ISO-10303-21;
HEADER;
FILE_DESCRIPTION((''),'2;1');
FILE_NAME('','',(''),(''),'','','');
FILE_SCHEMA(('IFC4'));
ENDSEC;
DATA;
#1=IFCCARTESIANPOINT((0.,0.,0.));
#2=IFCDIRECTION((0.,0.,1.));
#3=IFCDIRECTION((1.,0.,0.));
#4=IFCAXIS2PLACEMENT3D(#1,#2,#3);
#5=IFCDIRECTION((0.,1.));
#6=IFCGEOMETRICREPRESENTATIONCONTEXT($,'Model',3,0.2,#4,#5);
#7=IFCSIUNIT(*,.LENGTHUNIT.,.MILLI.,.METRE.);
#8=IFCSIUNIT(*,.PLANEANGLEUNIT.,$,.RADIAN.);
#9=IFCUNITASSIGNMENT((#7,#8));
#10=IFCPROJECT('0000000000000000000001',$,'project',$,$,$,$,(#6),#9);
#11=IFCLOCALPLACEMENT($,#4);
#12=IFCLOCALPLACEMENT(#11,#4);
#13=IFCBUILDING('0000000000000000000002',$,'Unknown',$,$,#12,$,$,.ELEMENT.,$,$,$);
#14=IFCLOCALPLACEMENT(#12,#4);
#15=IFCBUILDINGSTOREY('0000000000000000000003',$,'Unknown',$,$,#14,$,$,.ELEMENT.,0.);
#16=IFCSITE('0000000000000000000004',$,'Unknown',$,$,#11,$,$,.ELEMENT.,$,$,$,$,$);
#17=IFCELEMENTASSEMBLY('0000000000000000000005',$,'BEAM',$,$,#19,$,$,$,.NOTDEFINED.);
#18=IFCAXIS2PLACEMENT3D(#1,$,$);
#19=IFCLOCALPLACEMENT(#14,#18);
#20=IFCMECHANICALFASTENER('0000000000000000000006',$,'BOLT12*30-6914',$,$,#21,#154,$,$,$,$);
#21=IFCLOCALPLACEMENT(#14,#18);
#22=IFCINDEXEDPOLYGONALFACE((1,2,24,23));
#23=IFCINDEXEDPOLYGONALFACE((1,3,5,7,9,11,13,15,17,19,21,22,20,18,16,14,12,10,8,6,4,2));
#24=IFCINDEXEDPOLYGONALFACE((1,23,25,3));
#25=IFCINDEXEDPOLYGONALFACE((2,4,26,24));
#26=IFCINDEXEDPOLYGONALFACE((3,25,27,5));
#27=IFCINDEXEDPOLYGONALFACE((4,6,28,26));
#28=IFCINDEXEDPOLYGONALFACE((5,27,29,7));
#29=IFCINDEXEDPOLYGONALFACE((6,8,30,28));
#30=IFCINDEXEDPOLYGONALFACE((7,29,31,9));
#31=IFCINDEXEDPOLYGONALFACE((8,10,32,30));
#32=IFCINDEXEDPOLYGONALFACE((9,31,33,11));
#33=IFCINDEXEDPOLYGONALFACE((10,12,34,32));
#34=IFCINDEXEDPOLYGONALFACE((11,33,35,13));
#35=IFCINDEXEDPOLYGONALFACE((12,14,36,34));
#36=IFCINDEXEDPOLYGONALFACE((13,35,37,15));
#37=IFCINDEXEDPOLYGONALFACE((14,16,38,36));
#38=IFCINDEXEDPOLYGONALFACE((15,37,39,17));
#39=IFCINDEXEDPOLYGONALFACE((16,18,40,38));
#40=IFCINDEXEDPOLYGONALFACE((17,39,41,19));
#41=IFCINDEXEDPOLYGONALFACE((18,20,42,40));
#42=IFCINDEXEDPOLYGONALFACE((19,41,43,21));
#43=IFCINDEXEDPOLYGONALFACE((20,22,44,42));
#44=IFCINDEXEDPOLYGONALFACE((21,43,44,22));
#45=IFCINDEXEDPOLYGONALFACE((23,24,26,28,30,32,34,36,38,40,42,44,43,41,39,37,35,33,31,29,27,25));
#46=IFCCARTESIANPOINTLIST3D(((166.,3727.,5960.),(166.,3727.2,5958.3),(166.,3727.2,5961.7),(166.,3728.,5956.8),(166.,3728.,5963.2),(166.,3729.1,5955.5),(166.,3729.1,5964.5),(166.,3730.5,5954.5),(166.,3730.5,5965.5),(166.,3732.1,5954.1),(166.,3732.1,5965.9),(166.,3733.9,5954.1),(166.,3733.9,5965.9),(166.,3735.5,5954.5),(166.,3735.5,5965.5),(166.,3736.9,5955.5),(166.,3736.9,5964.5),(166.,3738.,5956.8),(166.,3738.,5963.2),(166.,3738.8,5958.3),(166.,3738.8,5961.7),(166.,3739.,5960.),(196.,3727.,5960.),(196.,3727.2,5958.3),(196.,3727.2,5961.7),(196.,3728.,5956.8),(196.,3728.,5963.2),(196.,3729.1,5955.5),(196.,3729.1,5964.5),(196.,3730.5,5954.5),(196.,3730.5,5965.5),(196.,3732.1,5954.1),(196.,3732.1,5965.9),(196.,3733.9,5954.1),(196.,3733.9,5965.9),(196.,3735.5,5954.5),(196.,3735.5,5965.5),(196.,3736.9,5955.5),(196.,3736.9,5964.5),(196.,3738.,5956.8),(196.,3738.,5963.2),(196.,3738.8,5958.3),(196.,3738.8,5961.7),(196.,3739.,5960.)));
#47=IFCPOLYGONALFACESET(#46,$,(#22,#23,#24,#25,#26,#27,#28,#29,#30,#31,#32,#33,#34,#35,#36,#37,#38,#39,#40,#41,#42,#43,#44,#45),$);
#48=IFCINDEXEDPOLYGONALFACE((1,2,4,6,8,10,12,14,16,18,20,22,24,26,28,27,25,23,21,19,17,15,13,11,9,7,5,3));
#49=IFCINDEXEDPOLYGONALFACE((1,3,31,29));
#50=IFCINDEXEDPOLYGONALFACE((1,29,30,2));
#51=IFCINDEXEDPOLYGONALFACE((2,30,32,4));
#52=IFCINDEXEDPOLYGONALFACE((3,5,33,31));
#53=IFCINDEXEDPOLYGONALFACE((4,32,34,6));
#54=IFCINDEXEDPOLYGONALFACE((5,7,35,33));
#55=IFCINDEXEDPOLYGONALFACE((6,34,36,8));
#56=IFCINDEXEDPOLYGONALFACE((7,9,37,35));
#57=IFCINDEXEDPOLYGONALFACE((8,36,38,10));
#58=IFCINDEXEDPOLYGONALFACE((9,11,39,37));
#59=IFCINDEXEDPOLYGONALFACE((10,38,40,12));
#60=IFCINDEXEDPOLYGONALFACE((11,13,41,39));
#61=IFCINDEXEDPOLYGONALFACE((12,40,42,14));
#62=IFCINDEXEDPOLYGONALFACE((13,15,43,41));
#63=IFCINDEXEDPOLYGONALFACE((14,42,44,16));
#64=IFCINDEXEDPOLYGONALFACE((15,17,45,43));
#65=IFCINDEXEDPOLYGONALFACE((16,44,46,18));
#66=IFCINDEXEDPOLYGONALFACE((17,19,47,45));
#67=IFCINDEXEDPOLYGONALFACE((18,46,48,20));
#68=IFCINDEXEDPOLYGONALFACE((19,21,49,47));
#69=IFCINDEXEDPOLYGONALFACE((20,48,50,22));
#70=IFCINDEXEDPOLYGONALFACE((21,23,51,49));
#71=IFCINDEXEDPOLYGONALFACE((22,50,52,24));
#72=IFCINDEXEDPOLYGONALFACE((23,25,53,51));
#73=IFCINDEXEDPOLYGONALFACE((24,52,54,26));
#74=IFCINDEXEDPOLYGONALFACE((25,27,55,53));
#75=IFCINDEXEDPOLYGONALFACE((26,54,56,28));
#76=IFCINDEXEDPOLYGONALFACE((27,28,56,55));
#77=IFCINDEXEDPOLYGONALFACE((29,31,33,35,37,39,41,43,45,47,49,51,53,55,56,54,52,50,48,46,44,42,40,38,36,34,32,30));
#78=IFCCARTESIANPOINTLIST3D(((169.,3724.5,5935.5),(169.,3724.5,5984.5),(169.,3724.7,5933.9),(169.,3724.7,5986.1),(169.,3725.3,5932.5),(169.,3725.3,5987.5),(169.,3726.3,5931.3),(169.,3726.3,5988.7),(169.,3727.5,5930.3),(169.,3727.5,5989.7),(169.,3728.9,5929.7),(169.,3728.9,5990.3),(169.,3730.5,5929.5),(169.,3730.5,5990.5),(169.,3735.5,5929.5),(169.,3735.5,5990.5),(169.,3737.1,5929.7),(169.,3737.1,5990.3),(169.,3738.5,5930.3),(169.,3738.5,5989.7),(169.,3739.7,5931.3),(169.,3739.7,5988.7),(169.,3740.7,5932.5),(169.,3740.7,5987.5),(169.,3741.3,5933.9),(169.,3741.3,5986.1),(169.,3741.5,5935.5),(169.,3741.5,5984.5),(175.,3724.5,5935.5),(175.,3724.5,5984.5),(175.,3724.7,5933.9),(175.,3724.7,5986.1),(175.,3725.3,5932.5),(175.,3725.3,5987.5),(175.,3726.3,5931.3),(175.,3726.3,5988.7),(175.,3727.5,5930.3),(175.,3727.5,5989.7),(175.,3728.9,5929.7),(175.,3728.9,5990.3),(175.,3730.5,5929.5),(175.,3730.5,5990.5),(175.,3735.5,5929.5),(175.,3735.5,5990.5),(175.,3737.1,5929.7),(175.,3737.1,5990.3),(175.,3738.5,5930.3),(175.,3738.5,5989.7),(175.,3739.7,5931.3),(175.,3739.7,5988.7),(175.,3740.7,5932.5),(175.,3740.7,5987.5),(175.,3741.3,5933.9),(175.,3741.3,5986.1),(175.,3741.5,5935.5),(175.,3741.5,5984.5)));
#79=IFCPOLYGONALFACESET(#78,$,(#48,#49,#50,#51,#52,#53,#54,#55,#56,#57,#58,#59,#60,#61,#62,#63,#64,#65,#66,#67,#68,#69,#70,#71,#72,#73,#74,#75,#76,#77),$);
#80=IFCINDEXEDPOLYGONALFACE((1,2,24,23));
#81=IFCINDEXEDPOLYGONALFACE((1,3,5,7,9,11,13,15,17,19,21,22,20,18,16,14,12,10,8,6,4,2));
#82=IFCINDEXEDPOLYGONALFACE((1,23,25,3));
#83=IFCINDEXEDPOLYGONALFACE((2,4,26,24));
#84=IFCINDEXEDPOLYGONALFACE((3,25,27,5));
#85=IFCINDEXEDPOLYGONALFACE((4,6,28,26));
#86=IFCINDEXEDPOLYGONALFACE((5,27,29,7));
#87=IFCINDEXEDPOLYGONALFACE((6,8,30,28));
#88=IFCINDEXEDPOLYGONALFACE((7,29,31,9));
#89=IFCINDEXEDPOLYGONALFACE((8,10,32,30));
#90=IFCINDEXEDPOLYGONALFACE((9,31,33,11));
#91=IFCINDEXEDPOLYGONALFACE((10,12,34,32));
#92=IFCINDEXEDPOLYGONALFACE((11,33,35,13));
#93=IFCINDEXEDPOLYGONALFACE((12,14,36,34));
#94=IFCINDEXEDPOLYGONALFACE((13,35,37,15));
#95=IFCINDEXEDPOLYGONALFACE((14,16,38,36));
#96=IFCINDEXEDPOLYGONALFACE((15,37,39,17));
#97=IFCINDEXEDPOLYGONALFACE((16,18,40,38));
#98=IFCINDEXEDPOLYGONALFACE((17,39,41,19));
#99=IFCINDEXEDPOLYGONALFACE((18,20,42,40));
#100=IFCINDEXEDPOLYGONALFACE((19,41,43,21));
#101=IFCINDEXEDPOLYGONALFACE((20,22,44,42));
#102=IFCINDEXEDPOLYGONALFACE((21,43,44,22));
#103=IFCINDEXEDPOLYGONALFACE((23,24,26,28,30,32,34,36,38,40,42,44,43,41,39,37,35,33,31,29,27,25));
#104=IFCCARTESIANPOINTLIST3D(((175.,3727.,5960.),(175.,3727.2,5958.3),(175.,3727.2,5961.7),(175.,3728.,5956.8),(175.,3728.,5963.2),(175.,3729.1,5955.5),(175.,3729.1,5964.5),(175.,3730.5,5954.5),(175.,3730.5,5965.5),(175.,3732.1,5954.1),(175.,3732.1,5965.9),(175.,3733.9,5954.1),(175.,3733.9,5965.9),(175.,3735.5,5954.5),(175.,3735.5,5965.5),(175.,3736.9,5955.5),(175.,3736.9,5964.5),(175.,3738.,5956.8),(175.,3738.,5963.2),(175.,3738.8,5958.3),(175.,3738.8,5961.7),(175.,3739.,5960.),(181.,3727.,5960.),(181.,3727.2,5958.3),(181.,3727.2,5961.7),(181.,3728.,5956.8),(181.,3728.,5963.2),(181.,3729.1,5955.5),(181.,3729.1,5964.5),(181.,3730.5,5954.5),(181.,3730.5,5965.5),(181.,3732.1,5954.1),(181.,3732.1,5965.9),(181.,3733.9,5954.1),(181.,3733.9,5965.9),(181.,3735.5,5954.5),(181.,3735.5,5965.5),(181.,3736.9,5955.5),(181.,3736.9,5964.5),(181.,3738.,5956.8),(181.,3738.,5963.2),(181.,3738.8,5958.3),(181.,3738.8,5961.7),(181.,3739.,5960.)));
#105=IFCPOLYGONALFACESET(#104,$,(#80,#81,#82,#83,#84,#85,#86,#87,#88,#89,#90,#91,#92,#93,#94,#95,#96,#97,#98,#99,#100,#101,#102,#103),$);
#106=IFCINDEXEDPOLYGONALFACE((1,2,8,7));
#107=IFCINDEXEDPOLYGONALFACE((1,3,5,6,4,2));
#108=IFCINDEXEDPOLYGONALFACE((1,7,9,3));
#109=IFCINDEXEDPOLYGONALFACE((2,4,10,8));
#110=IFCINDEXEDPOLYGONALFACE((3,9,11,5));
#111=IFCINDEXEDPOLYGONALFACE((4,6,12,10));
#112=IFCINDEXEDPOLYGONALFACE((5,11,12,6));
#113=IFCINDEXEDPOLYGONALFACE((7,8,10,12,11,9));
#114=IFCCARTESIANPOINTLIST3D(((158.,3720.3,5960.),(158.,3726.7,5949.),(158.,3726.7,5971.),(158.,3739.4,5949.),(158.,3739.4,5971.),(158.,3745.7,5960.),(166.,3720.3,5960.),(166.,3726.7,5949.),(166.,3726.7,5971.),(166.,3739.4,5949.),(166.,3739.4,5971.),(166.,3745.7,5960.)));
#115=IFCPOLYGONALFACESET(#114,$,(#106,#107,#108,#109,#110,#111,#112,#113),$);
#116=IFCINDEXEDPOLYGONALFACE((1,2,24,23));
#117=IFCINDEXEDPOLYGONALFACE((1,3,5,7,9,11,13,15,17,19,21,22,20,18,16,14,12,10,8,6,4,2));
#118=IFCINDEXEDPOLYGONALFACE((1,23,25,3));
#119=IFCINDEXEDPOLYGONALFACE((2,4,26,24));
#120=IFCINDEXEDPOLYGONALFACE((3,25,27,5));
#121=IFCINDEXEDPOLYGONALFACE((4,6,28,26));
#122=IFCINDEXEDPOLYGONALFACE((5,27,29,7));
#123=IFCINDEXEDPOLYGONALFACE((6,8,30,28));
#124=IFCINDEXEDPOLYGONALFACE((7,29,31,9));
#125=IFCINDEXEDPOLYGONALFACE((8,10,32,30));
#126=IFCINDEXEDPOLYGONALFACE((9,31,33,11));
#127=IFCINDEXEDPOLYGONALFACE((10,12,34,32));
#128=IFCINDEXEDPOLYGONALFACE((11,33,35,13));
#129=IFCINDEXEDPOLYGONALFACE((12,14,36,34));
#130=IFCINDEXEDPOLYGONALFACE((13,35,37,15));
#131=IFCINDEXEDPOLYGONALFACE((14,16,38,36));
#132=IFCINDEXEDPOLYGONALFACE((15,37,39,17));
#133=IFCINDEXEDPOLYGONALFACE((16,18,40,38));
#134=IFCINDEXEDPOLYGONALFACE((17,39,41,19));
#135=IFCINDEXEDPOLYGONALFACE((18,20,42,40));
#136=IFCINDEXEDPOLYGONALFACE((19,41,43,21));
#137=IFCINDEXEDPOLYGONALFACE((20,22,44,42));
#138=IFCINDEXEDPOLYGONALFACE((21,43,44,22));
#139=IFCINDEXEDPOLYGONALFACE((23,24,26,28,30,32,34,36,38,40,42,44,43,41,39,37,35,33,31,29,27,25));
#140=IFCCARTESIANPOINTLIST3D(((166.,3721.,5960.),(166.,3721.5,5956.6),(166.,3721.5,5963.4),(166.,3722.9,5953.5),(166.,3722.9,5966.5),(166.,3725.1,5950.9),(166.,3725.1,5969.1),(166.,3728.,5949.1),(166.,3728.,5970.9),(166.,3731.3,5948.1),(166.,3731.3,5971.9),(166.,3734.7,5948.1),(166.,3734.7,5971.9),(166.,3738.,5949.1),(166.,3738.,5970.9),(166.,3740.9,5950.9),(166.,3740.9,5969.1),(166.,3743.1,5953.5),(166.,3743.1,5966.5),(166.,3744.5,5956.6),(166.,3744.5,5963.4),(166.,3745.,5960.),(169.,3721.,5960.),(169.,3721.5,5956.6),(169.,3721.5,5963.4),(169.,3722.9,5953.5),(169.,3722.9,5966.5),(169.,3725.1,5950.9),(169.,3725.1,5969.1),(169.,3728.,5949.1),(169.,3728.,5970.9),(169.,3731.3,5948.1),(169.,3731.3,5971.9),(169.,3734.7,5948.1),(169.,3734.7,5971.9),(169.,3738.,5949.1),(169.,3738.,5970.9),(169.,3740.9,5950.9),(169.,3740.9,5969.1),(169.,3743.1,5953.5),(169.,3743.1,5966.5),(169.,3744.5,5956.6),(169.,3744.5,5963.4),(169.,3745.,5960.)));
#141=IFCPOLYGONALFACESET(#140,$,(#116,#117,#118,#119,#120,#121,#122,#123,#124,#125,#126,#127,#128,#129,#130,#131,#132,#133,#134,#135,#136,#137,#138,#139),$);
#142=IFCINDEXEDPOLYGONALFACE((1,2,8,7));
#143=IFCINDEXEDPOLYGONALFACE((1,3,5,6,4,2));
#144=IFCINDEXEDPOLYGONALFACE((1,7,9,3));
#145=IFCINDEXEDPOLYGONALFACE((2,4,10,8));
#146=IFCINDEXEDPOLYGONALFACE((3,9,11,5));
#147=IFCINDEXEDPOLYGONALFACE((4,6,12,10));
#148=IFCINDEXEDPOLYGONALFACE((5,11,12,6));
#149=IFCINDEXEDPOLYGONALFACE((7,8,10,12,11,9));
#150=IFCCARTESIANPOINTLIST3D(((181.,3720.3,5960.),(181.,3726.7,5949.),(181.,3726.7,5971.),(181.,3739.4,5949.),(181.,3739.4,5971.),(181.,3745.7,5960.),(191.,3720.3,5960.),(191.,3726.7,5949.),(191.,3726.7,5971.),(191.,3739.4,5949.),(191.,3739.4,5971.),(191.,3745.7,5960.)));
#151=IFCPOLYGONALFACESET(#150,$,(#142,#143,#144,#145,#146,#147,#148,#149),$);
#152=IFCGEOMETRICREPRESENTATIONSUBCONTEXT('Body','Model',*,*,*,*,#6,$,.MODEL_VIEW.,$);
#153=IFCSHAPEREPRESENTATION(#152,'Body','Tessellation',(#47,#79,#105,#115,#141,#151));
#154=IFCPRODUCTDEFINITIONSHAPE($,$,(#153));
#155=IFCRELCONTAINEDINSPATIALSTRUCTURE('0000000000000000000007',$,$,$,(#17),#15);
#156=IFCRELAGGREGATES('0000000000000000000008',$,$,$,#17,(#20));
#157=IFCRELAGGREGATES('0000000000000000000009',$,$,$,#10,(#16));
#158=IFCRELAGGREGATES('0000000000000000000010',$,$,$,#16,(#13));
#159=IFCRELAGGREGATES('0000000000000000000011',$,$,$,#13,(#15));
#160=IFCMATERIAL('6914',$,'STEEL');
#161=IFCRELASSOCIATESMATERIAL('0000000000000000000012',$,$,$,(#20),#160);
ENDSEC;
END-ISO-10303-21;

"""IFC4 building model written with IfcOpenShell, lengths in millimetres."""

from ifc_helpers import new_model, si_unit, direction, frame, origin_with_axes, place, context, subcontext, project, spatial, line, arc, indexed_curve, outline, extrude, source, transform, mapped, material, element, aggregate, save


model = new_model("IFC4")

# Units and contexts
model_context = context("Model", 3, precision=0.2, world=origin_with_axes(), true_north=direction((0.0, 1.0)))
body_context = subcontext(model_context, "Body", "Model", "MODEL_VIEW")
ifc_project = project(units=[si_unit("LENGTHUNIT", "METRE", prefix="MILLI"), si_unit("PLANEANGLEUNIT", "RADIAN")], contexts=[model_context])

# Site, building, storey
site_placement = place(None, origin_with_axes())
site = spatial("IfcSite", under=ifc_project, at=site_placement, Name="Unknown", CompositionType="ELEMENT")
building_placement = place(site_placement, origin_with_axes())
building = spatial("IfcBuilding", under=site, at=building_placement, Name="Unknown", CompositionType="ELEMENT")
storey_placement = place(building_placement, origin_with_axes())
storey = spatial("IfcBuildingStorey", under=building, at=storey_placement, Name="Unknown", CompositionType="ELEMENT", Elevation=0.0)

# Element assembly
assembly_1_placement = place(storey_placement, frame((175.5, 3720.0, 6980.0), z_axis=(0.0, -1.0, 0.000002), x_axis=(1.0, 0.0, 0.0)))
assembly_1 = element("IfcElementAssembly", 1, at=assembly_1_placement, inside=storey, Name="BEAM", PredefinedType="NOTDEFINED")

# Mechanical fastener
ifc_material_1 = material(Name="6914", Category="STEEL")
shared_shape_1 = source(origin_with_axes(), body_context, "Body", "SweptSolid", [
    extrude(outline(indexed_curve([(6.0, 0.0), (0.0, 6.0), (-6.0, 0.0), (0.0, -6.0)], segments=[arc(1, 2, 3), arc(3, 4, 1)])), frame((0.0, 0.0, 9.0), z_axis=(0.0, -0.000002, -1.0), x_axis=(0.0, 1.0, 0.0)), (0.0, 0.0, 1.0), 30.0),
    extrude(outline(indexed_curve([(-2.5, 30.5), (2.5, 30.5), (2.5, 30.5), (6.7, 28.7), (8.5, 24.5), (8.5, -24.5), (6.7, -28.7), (2.5, -30.5), (-2.5, -30.5), (-3.0, -30.5), (-8.5, -24.5), (-8.5, 24.5), (-6.7, 28.7)], segments=[line(1, 2, 3), arc(3, 4, 5), line(5, 6), arc(6, 7, 8), line(8, 9), arc(9, 10, 11), line(11, 12), arc(12, 13, 1)])), frame((0.0, 0.0, 6.0), z_axis=(0.0, -0.000002, -1.0), x_axis=(0.0, 1.0, 0.0)), (0.0, 0.0, 1.0), 6.0),
    extrude(outline(indexed_curve([(6.0, 0.0), (0.0, 6.0), (-6.0, 0.0), (0.0, -6.0)], segments=[arc(1, 2, 3), arc(3, 4, 1)])), frame((0.0, 0.0, 0.0), z_axis=(0.0, -0.000002, -1.0), x_axis=(0.0, 1.0, 0.0)), (0.0, 0.0, 1.0), 6.0),
    extrude(outline(indexed_curve([(12.7, 0.0), (6.4, 11.0), (-6.4, 11.0), (-12.7, 0.0), (-6.4, -11.0), (6.4, -11.0)], segments=[line(1, 2, 3, 4, 5, 6, 1)])), frame((0.0, 0.0, 17.0), z_axis=(0.0, -0.000002, -1.0), x_axis=(0.0, 1.0, 0.0)), (0.0, 0.0, 1.0), 8.0),
    extrude(outline(indexed_curve([(12.0, 0.0), (0.0, 12.0), (-12.0, 0.0), (0.0, -12.0)], segments=[arc(1, 2, 3), arc(3, 4, 1)])), frame((0.0, 0.0, 9.0), z_axis=(0.0, -0.000002, -1.0), x_axis=(0.0, 1.0, 0.0)), (0.0, 0.0, 1.0), 3.0),
    extrude(outline(indexed_curve([(12.7, 0.0), (6.4, 11.0), (-6.4, 11.0), (-12.7, 0.0), (-6.4, -11.0), (6.4, -11.0)], segments=[line(1, 2, 3, 4, 5, 6, 1)])), frame((0.0, 0.0, -6.0), z_axis=(0.0, -0.000002, -1.0), x_axis=(0.0, 1.0, 0.0)), (0.0, 0.0, 1.0), 10.0),
])
mechanical_fastener_1_placement = place(assembly_1_placement, frame((-0.5, -1020.0, -13.0), z_axis=(-1.0, 0.0, 0.0), x_axis=(0.0, 1.0, 0.0)))
mechanical_fastener_1 = element("IfcMechanicalFastener", 2, at=mechanical_fastener_1_placement, material=ifc_material_1, Name="BOLT12*30-6914", context=body_context, shape_type="MappedRepresentation", body=[
    mapped(shared_shape_1, transform((0.0, 0.0, 0.0))),
])
aggregate(assembly_1, [mechanical_fastener_1])

save(model, "model.ifc")
